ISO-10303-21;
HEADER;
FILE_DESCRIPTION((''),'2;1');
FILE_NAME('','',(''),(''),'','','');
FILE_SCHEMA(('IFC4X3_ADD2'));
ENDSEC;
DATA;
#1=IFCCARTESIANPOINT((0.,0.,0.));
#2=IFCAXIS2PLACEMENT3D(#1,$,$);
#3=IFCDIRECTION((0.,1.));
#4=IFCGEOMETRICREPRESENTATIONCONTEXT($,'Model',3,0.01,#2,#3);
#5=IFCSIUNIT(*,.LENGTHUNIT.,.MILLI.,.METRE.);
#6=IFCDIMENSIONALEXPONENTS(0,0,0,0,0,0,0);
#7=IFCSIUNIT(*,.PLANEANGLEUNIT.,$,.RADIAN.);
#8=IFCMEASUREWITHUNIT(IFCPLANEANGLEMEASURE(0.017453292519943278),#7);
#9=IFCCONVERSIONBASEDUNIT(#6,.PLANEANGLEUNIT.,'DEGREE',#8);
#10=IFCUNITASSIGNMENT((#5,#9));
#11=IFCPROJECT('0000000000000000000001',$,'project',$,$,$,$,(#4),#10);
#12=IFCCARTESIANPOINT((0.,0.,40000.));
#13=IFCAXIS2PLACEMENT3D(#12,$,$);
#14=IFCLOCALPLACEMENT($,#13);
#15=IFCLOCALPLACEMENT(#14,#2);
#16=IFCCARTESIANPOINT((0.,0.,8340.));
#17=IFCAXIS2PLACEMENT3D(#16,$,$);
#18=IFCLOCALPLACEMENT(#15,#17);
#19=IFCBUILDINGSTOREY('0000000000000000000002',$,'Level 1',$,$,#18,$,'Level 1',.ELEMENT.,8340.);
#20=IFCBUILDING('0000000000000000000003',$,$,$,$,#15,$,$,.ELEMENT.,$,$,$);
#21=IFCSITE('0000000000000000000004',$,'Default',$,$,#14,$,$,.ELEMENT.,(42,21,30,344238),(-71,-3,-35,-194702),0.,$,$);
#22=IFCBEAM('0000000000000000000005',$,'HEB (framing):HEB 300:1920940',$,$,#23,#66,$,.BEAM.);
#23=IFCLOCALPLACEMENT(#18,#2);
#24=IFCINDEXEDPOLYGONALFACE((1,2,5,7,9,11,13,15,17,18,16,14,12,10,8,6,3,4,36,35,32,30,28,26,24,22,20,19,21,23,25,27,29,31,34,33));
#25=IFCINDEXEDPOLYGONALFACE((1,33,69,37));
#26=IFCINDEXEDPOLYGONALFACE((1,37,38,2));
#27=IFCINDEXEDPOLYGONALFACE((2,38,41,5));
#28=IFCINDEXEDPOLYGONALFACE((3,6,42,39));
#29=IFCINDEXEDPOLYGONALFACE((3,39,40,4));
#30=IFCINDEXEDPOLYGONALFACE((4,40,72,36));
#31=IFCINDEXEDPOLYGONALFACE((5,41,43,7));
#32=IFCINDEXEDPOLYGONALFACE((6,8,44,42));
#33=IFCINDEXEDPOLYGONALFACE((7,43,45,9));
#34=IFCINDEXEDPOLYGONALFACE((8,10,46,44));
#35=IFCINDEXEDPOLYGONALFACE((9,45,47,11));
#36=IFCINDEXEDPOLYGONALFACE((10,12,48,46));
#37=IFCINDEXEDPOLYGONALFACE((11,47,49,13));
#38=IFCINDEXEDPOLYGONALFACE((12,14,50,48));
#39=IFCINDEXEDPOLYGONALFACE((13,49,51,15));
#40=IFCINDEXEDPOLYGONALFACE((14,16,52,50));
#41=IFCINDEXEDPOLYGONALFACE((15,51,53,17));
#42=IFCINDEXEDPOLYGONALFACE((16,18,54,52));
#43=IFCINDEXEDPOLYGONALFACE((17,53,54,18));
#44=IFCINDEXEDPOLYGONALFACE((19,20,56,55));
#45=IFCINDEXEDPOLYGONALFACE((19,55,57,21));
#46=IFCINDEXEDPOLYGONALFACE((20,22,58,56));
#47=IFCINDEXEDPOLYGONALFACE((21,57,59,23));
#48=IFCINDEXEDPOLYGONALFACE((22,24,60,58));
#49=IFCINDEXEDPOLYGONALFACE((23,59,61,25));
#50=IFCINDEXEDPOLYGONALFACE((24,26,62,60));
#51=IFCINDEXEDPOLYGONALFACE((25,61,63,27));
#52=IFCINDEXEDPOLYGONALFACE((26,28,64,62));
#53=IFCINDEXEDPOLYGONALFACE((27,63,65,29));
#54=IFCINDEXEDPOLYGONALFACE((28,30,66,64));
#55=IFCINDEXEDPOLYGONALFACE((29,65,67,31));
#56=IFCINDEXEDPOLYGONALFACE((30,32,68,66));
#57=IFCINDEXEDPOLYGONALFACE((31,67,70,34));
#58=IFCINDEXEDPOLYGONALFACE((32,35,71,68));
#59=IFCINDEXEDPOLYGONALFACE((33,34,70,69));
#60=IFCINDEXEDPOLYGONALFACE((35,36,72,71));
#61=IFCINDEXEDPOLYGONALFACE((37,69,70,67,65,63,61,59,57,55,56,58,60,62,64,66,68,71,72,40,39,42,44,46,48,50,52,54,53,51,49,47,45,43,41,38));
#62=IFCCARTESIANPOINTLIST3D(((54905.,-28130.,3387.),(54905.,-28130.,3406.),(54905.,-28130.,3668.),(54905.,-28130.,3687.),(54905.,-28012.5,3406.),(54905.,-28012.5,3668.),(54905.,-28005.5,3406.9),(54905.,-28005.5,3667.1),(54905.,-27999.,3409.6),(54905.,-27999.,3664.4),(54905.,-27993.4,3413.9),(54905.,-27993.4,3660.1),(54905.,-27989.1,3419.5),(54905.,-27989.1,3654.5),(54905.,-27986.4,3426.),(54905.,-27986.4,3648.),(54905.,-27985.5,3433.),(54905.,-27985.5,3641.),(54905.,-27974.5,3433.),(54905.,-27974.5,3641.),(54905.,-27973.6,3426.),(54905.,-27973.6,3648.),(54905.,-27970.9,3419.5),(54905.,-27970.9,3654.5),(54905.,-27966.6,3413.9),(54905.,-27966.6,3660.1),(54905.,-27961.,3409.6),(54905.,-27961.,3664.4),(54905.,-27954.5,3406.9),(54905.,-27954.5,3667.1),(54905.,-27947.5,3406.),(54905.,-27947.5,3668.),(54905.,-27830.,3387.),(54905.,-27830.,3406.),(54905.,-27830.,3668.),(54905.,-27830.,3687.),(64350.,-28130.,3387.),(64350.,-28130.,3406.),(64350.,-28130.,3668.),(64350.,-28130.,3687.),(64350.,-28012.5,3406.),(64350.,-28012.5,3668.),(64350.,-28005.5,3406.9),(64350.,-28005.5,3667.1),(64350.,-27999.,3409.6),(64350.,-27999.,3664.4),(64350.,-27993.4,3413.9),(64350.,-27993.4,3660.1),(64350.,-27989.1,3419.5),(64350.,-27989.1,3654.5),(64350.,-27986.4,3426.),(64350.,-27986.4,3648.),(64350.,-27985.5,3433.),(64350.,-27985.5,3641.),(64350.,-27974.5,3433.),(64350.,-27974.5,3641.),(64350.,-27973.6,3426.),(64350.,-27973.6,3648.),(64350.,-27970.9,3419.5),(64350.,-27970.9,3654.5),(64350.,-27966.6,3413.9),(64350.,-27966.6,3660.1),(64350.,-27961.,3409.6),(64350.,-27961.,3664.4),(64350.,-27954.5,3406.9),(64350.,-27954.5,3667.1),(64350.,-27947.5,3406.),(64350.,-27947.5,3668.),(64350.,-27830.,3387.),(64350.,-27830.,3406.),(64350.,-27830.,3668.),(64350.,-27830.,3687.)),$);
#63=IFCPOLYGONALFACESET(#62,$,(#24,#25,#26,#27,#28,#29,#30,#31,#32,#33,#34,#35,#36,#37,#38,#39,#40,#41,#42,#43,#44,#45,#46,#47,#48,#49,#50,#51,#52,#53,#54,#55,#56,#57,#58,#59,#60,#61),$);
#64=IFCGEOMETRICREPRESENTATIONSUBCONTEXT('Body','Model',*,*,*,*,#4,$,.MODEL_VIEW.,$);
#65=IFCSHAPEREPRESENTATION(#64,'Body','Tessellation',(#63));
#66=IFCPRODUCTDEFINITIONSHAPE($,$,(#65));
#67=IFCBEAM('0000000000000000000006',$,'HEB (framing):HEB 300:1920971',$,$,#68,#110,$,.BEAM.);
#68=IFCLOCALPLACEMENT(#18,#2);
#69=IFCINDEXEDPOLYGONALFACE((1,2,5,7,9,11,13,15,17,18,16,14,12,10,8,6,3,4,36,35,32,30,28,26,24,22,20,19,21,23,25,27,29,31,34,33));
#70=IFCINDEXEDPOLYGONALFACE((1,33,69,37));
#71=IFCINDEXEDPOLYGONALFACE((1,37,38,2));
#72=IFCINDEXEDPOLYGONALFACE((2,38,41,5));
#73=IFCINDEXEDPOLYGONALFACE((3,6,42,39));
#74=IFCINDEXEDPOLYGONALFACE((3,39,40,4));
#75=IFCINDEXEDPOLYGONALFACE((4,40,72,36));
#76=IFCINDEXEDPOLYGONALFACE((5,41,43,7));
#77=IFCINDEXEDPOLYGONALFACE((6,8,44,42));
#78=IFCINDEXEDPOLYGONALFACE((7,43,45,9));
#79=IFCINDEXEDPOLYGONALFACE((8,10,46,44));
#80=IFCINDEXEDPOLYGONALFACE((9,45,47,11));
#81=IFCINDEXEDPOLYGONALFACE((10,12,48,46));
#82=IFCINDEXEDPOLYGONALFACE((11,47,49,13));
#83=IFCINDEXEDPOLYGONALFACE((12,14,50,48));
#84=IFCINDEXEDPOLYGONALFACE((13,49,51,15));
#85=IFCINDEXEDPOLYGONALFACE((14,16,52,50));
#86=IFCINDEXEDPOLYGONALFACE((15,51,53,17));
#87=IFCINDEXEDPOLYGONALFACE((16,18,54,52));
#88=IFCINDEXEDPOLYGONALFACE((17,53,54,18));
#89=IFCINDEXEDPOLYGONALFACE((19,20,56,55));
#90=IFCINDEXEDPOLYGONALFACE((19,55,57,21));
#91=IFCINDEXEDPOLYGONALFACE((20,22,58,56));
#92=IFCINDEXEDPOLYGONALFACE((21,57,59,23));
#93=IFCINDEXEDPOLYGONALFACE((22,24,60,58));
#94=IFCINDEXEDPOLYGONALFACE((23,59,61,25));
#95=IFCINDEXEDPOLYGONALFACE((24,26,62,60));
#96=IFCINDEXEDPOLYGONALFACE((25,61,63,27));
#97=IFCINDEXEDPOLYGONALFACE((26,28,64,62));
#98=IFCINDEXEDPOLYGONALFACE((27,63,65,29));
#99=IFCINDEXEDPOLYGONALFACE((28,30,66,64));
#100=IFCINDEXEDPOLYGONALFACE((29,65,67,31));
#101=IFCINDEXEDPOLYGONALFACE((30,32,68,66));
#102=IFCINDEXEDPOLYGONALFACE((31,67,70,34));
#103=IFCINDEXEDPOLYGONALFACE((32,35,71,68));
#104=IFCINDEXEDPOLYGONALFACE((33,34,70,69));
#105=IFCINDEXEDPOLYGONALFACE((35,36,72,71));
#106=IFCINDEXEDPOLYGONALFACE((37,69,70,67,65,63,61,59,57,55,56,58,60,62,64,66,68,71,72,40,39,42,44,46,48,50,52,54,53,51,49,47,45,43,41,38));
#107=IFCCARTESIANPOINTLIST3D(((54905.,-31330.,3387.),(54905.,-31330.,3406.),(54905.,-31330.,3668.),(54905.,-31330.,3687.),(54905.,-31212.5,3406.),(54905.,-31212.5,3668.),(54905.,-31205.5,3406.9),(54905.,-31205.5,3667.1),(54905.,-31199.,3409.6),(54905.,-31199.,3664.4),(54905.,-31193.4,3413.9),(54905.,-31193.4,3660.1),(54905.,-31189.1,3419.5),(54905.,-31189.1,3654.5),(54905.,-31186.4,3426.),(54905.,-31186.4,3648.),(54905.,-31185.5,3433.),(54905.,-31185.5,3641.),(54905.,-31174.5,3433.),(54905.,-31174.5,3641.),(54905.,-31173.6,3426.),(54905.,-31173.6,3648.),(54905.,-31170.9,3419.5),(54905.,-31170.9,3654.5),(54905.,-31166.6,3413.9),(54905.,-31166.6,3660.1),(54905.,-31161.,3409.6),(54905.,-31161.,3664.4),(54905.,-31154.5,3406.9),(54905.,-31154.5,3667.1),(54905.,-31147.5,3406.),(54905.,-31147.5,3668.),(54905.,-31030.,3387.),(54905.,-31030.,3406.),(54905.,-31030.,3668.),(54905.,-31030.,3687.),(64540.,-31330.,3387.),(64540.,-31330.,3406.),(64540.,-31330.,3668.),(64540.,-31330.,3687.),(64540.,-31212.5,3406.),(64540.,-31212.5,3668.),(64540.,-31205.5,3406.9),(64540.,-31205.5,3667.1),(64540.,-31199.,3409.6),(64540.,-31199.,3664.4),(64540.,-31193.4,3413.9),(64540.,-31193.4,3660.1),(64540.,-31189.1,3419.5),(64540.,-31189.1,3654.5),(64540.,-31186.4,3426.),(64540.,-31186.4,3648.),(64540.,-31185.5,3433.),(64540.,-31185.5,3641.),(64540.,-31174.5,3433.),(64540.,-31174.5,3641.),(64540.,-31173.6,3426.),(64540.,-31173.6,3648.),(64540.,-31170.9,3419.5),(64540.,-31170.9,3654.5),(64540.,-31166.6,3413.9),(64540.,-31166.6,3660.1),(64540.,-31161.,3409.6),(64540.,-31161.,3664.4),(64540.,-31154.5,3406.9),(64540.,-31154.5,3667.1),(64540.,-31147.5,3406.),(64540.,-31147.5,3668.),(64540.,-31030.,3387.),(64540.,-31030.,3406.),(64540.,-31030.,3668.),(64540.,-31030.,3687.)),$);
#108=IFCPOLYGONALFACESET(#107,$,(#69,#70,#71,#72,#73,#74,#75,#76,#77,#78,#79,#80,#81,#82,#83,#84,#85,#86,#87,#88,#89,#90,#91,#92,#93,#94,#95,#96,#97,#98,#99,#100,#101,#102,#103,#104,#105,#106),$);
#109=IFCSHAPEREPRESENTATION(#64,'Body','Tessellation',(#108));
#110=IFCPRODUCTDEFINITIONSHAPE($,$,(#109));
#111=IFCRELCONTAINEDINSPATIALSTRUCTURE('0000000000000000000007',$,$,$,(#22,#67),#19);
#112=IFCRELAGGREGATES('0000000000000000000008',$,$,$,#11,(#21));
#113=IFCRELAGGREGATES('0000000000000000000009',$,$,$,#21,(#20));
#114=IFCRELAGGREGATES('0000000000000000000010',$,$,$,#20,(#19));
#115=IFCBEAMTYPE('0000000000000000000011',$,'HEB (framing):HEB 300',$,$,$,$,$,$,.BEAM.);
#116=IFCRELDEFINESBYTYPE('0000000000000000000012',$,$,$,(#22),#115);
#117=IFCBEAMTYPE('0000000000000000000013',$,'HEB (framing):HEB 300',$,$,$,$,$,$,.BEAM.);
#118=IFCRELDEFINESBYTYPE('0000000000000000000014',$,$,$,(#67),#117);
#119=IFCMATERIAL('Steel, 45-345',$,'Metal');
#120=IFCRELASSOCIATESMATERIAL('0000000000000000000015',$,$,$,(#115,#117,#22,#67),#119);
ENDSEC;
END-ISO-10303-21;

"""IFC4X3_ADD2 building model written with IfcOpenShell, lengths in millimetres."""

from ifc_helpers import new_model, entity, si_unit, converted_unit, direction, frame, frame_2d, origin, place, context, subcontext, project, spatial, polyline, circle_curve, parameter, trimmed, segment, composite_curve, outline, extrude, source, transform, mapped, material, material_profile, profile_set, profile_usage, type_object, type_shapes, element, save


model = new_model("IFC4X3_ADD2")

# Units and contexts
model_context = context("Model", 3, precision=0.01, world=origin(), true_north=direction((0.0, 1.0)))
body_context = subcontext(model_context, "Body", "Model", "MODEL_VIEW")
ifc_project = project(units=[si_unit("LENGTHUNIT", "METRE", prefix="MILLI"), converted_unit("PLANEANGLEUNIT", "DEGREE", entity("IfcPlaneAngleMeasure", 0.017453292519943278), si_unit("PLANEANGLEUNIT", "RADIAN"), dimensions=[0, 0, 0, 0, 0, 0, 0])], contexts=[model_context])

# Site, building, storey
site_placement = place(None, frame((0.0, 0.0, 40000.0)))
site = spatial("IfcSite", under=ifc_project, at=site_placement, Name="Default", CompositionType="ELEMENT", RefLatitude=(42, 21, 30, 344238), RefLongitude=(-71, -3, -35, -194702), RefElevation=0.0)
building_placement = place(site_placement, origin())
building = spatial("IfcBuilding", under=site, at=building_placement, CompositionType="ELEMENT")
storey_placement = place(building_placement, frame((0.0, 0.0, 8340.0)))
storey = spatial("IfcBuildingStorey", under=building, at=storey_placement, Name="Level 1", LongName="Level 1", CompositionType="ELEMENT", Elevation=8340.0)

# Shared definitions
ifc_material_1 = material(Name="Steel, 45-345", Category="Metal")

# Beams
ifc_material_profile_1 = material_profile(ifc_material_1, outline(composite_curve([segment(polyline([(-150.0, -131.0), (-150.0, -150.0)]), True, "CONTINUOUS"), segment(polyline([(-150.0, -150.0), (150.0, -150.0)]), True, "CONTINUOUS"), segment(polyline([(150.0, -150.0), (150.0, -131.0)]), True, "CONTINUOUS"), segment(polyline([(150.0, -131.0), (32.5, -131.0)]), True, "CONTINUOUS"), segment(trimmed(circle_curve(frame_2d((32.5, -104.0), x_axis=(1.0, 0.0)), 27.0), [parameter(180.0)], [parameter(270.0)], True, "PARAMETER"), False, "CONTINUOUS"), segment(polyline([(5.5, -104.0), (5.5, 104.0)]), True, "CONTINUOUS"), segment(trimmed(circle_curve(frame_2d((32.5, 104.0), x_axis=(1.0, 0.0)), 27.0), [parameter(90.0)], [parameter(180.0)], True, "PARAMETER"), False, "CONTINUOUS"), segment(polyline([(32.5, 131.0), (150.0, 131.0)]), True, "CONTINUOUS"), segment(polyline([(150.0, 131.0), (150.0, 150.0)]), True, "CONTINUOUS"), segment(polyline([(150.0, 150.0), (-150.0, 150.0)]), True, "CONTINUOUS"), segment(polyline([(-150.0, 150.0), (-150.0, 131.0)]), True, "CONTINUOUS"), segment(polyline([(-150.0, 131.0), (-32.5, 131.0)]), True, "CONTINUOUS"), segment(trimmed(circle_curve(frame_2d((-32.5, 104.0), x_axis=(1.0, 0.0)), 27.0), [parameter(360.0)], [parameter(90.0)], True, "PARAMETER"), False, "CONTINUOUS"), segment(polyline([(-5.5, 104.0), (-5.5, -104.0)]), True, "CONTINUOUS"), segment(trimmed(circle_curve(frame_2d((-32.5, -104.0), x_axis=(1.0, 0.0)), 27.0), [parameter(270.0)], [parameter(0.0)], True, "PARAMETER"), False, "CONTINUOUS"), segment(polyline([(-32.5, -131.0), (-150.0, -131.0)]), True, "CONTINUOUS")], self_intersect=False)), Name="HEB 300")
ifc_profile_set_1 = profile_set([ifc_material_profile_1], Name="HEB 300")
ifc_profile_usage_1 = profile_usage(ifc_profile_set_1, cardinal=8)
beam_type_1 = type_object("IfcBeamType", Name="HEB (framing):HEB 300", PredefinedType="BEAM", material=ifc_profile_set_1)
shared_shape_1 = source(origin(), body_context, "Body", "SweptSolid", [
    extrude(outline(composite_curve([segment(polyline([(-150.0, -131.0), (-150.0, -150.0)]), True, "CONTINUOUS"), segment(polyline([(-150.0, -150.0), (150.0, -150.0)]), True, "CONTINUOUS"), segment(polyline([(150.0, -150.0), (150.0, -131.0)]), True, "CONTINUOUS"), segment(polyline([(150.0, -131.0), (32.5, -131.0)]), True, "CONTINUOUS"), segment(trimmed(circle_curve(frame_2d((32.5, -104.0), x_axis=(1.0, 0.0)), 27.0), [parameter(180.0)], [parameter(270.0)], True, "PARAMETER"), False, "CONTINUOUS"), segment(polyline([(5.5, -104.0), (5.5, 104.0)]), True, "CONTINUOUS"), segment(trimmed(circle_curve(frame_2d((32.5, 104.0), x_axis=(1.0, 0.0)), 27.0), [parameter(90.0)], [parameter(180.0)], True, "PARAMETER"), False, "CONTINUOUS"), segment(polyline([(32.5, 131.0), (150.0, 131.0)]), True, "CONTINUOUS"), segment(polyline([(150.0, 131.0), (150.0, 150.0)]), True, "CONTINUOUS"), segment(polyline([(150.0, 150.0), (-150.0, 150.0)]), True, "CONTINUOUS"), segment(polyline([(-150.0, 150.0), (-150.0, 131.0)]), True, "CONTINUOUS"), segment(polyline([(-150.0, 131.0), (-32.5, 131.0)]), True, "CONTINUOUS"), segment(trimmed(circle_curve(frame_2d((-32.5, 104.0), x_axis=(1.0, 0.0)), 27.0), [parameter(360.0)], [parameter(90.0)], True, "PARAMETER"), False, "CONTINUOUS"), segment(polyline([(-5.5, 104.0), (-5.5, -104.0)]), True, "CONTINUOUS"), segment(trimmed(circle_curve(frame_2d((-32.5, -104.0), x_axis=(1.0, 0.0)), 27.0), [parameter(270.0)], [parameter(0.0)], True, "PARAMETER"), False, "CONTINUOUS"), segment(polyline([(-32.5, -131.0), (-150.0, -131.0)]), True, "CONTINUOUS")], self_intersect=False)), frame((-4697.5, 0.0, 0.0), z_axis=(-1.0, 0.0, 0.0), x_axis=(0.0, -1.0, 0.0)), (0.0, 0.0, -1.0), 9445.0),
])
type_shapes(beam_type_1, [shared_shape_1])
beam_1_placement = place(storey_placement, frame((59602.5, -27980.0, 3537.0)))
element("IfcBeam", 1, at=beam_1_placement, inside=storey, type_object=beam_type_1, material=ifc_profile_usage_1, Name="HEB (framing):HEB 300:1920940", PredefinedType="BEAM", context=body_context, shape_type="MappedRepresentation", body=[
    mapped(shared_shape_1, transform((0.0, 0.0, 0.0), scale=1.0)),
])
beam_type_2 = type_object("IfcBeamType", Name="HEB (framing):HEB 300", PredefinedType="BEAM", material=ifc_profile_set_1)
shared_shape_2 = source(origin(), body_context, "Body", "SweptSolid", [
    extrude(outline(composite_curve([segment(polyline([(-150.0, -131.0), (-150.0, -150.0)]), True, "CONTINUOUS"), segment(polyline([(-150.0, -150.0), (150.0, -150.0)]), True, "CONTINUOUS"), segment(polyline([(150.0, -150.0), (150.0, -131.0)]), True, "CONTINUOUS"), segment(polyline([(150.0, -131.0), (32.5, -131.0)]), True, "CONTINUOUS"), segment(trimmed(circle_curve(frame_2d((32.5, -104.0), x_axis=(1.0, 0.0)), 27.0), [parameter(180.0)], [parameter(270.0)], True, "PARAMETER"), False, "CONTINUOUS"), segment(polyline([(5.5, -104.0), (5.5, 104.0)]), True, "CONTINUOUS"), segment(trimmed(circle_curve(frame_2d((32.5, 104.0), x_axis=(1.0, 0.0)), 27.0), [parameter(90.0)], [parameter(180.0)], True, "PARAMETER"), False, "CONTINUOUS"), segment(polyline([(32.5, 131.0), (150.0, 131.0)]), True, "CONTINUOUS"), segment(polyline([(150.0, 131.0), (150.0, 150.0)]), True, "CONTINUOUS"), segment(polyline([(150.0, 150.0), (-150.0, 150.0)]), True, "CONTINUOUS"), segment(polyline([(-150.0, 150.0), (-150.0, 131.0)]), True, "CONTINUOUS"), segment(polyline([(-150.0, 131.0), (-32.5, 131.0)]), True, "CONTINUOUS"), segment(trimmed(circle_curve(frame_2d((-32.5, 104.0), x_axis=(1.0, 0.0)), 27.0), [parameter(360.0)], [parameter(90.0)], True, "PARAMETER"), False, "CONTINUOUS"), segment(polyline([(-5.5, 104.0), (-5.5, -104.0)]), True, "CONTINUOUS"), segment(trimmed(circle_curve(frame_2d((-32.5, -104.0), x_axis=(1.0, 0.0)), 27.0), [parameter(270.0)], [parameter(0.0)], True, "PARAMETER"), False, "CONTINUOUS"), segment(polyline([(-32.5, -131.0), (-150.0, -131.0)]), True, "CONTINUOUS")], self_intersect=False)), frame((-4697.5, 0.0, 0.0), z_axis=(-1.0, 0.0, 0.0), x_axis=(0.0, -1.0, 0.0)), (0.0, 0.0, -1.0), 9635.0),
])
type_shapes(beam_type_2, [shared_shape_2])
beam_2_placement = place(storey_placement, frame((59602.5, -31180.0, 3537.0)))
element("IfcBeam", 2, at=beam_2_placement, inside=storey, type_object=beam_type_2, material=ifc_profile_usage_1, Name="HEB (framing):HEB 300:1920971", PredefinedType="BEAM", context=body_context, shape_type="MappedRepresentation", body=[
    mapped(shared_shape_2, transform((0.0, 0.0, 0.0), scale=1.0)),
])

save(model, "model.ifc")
